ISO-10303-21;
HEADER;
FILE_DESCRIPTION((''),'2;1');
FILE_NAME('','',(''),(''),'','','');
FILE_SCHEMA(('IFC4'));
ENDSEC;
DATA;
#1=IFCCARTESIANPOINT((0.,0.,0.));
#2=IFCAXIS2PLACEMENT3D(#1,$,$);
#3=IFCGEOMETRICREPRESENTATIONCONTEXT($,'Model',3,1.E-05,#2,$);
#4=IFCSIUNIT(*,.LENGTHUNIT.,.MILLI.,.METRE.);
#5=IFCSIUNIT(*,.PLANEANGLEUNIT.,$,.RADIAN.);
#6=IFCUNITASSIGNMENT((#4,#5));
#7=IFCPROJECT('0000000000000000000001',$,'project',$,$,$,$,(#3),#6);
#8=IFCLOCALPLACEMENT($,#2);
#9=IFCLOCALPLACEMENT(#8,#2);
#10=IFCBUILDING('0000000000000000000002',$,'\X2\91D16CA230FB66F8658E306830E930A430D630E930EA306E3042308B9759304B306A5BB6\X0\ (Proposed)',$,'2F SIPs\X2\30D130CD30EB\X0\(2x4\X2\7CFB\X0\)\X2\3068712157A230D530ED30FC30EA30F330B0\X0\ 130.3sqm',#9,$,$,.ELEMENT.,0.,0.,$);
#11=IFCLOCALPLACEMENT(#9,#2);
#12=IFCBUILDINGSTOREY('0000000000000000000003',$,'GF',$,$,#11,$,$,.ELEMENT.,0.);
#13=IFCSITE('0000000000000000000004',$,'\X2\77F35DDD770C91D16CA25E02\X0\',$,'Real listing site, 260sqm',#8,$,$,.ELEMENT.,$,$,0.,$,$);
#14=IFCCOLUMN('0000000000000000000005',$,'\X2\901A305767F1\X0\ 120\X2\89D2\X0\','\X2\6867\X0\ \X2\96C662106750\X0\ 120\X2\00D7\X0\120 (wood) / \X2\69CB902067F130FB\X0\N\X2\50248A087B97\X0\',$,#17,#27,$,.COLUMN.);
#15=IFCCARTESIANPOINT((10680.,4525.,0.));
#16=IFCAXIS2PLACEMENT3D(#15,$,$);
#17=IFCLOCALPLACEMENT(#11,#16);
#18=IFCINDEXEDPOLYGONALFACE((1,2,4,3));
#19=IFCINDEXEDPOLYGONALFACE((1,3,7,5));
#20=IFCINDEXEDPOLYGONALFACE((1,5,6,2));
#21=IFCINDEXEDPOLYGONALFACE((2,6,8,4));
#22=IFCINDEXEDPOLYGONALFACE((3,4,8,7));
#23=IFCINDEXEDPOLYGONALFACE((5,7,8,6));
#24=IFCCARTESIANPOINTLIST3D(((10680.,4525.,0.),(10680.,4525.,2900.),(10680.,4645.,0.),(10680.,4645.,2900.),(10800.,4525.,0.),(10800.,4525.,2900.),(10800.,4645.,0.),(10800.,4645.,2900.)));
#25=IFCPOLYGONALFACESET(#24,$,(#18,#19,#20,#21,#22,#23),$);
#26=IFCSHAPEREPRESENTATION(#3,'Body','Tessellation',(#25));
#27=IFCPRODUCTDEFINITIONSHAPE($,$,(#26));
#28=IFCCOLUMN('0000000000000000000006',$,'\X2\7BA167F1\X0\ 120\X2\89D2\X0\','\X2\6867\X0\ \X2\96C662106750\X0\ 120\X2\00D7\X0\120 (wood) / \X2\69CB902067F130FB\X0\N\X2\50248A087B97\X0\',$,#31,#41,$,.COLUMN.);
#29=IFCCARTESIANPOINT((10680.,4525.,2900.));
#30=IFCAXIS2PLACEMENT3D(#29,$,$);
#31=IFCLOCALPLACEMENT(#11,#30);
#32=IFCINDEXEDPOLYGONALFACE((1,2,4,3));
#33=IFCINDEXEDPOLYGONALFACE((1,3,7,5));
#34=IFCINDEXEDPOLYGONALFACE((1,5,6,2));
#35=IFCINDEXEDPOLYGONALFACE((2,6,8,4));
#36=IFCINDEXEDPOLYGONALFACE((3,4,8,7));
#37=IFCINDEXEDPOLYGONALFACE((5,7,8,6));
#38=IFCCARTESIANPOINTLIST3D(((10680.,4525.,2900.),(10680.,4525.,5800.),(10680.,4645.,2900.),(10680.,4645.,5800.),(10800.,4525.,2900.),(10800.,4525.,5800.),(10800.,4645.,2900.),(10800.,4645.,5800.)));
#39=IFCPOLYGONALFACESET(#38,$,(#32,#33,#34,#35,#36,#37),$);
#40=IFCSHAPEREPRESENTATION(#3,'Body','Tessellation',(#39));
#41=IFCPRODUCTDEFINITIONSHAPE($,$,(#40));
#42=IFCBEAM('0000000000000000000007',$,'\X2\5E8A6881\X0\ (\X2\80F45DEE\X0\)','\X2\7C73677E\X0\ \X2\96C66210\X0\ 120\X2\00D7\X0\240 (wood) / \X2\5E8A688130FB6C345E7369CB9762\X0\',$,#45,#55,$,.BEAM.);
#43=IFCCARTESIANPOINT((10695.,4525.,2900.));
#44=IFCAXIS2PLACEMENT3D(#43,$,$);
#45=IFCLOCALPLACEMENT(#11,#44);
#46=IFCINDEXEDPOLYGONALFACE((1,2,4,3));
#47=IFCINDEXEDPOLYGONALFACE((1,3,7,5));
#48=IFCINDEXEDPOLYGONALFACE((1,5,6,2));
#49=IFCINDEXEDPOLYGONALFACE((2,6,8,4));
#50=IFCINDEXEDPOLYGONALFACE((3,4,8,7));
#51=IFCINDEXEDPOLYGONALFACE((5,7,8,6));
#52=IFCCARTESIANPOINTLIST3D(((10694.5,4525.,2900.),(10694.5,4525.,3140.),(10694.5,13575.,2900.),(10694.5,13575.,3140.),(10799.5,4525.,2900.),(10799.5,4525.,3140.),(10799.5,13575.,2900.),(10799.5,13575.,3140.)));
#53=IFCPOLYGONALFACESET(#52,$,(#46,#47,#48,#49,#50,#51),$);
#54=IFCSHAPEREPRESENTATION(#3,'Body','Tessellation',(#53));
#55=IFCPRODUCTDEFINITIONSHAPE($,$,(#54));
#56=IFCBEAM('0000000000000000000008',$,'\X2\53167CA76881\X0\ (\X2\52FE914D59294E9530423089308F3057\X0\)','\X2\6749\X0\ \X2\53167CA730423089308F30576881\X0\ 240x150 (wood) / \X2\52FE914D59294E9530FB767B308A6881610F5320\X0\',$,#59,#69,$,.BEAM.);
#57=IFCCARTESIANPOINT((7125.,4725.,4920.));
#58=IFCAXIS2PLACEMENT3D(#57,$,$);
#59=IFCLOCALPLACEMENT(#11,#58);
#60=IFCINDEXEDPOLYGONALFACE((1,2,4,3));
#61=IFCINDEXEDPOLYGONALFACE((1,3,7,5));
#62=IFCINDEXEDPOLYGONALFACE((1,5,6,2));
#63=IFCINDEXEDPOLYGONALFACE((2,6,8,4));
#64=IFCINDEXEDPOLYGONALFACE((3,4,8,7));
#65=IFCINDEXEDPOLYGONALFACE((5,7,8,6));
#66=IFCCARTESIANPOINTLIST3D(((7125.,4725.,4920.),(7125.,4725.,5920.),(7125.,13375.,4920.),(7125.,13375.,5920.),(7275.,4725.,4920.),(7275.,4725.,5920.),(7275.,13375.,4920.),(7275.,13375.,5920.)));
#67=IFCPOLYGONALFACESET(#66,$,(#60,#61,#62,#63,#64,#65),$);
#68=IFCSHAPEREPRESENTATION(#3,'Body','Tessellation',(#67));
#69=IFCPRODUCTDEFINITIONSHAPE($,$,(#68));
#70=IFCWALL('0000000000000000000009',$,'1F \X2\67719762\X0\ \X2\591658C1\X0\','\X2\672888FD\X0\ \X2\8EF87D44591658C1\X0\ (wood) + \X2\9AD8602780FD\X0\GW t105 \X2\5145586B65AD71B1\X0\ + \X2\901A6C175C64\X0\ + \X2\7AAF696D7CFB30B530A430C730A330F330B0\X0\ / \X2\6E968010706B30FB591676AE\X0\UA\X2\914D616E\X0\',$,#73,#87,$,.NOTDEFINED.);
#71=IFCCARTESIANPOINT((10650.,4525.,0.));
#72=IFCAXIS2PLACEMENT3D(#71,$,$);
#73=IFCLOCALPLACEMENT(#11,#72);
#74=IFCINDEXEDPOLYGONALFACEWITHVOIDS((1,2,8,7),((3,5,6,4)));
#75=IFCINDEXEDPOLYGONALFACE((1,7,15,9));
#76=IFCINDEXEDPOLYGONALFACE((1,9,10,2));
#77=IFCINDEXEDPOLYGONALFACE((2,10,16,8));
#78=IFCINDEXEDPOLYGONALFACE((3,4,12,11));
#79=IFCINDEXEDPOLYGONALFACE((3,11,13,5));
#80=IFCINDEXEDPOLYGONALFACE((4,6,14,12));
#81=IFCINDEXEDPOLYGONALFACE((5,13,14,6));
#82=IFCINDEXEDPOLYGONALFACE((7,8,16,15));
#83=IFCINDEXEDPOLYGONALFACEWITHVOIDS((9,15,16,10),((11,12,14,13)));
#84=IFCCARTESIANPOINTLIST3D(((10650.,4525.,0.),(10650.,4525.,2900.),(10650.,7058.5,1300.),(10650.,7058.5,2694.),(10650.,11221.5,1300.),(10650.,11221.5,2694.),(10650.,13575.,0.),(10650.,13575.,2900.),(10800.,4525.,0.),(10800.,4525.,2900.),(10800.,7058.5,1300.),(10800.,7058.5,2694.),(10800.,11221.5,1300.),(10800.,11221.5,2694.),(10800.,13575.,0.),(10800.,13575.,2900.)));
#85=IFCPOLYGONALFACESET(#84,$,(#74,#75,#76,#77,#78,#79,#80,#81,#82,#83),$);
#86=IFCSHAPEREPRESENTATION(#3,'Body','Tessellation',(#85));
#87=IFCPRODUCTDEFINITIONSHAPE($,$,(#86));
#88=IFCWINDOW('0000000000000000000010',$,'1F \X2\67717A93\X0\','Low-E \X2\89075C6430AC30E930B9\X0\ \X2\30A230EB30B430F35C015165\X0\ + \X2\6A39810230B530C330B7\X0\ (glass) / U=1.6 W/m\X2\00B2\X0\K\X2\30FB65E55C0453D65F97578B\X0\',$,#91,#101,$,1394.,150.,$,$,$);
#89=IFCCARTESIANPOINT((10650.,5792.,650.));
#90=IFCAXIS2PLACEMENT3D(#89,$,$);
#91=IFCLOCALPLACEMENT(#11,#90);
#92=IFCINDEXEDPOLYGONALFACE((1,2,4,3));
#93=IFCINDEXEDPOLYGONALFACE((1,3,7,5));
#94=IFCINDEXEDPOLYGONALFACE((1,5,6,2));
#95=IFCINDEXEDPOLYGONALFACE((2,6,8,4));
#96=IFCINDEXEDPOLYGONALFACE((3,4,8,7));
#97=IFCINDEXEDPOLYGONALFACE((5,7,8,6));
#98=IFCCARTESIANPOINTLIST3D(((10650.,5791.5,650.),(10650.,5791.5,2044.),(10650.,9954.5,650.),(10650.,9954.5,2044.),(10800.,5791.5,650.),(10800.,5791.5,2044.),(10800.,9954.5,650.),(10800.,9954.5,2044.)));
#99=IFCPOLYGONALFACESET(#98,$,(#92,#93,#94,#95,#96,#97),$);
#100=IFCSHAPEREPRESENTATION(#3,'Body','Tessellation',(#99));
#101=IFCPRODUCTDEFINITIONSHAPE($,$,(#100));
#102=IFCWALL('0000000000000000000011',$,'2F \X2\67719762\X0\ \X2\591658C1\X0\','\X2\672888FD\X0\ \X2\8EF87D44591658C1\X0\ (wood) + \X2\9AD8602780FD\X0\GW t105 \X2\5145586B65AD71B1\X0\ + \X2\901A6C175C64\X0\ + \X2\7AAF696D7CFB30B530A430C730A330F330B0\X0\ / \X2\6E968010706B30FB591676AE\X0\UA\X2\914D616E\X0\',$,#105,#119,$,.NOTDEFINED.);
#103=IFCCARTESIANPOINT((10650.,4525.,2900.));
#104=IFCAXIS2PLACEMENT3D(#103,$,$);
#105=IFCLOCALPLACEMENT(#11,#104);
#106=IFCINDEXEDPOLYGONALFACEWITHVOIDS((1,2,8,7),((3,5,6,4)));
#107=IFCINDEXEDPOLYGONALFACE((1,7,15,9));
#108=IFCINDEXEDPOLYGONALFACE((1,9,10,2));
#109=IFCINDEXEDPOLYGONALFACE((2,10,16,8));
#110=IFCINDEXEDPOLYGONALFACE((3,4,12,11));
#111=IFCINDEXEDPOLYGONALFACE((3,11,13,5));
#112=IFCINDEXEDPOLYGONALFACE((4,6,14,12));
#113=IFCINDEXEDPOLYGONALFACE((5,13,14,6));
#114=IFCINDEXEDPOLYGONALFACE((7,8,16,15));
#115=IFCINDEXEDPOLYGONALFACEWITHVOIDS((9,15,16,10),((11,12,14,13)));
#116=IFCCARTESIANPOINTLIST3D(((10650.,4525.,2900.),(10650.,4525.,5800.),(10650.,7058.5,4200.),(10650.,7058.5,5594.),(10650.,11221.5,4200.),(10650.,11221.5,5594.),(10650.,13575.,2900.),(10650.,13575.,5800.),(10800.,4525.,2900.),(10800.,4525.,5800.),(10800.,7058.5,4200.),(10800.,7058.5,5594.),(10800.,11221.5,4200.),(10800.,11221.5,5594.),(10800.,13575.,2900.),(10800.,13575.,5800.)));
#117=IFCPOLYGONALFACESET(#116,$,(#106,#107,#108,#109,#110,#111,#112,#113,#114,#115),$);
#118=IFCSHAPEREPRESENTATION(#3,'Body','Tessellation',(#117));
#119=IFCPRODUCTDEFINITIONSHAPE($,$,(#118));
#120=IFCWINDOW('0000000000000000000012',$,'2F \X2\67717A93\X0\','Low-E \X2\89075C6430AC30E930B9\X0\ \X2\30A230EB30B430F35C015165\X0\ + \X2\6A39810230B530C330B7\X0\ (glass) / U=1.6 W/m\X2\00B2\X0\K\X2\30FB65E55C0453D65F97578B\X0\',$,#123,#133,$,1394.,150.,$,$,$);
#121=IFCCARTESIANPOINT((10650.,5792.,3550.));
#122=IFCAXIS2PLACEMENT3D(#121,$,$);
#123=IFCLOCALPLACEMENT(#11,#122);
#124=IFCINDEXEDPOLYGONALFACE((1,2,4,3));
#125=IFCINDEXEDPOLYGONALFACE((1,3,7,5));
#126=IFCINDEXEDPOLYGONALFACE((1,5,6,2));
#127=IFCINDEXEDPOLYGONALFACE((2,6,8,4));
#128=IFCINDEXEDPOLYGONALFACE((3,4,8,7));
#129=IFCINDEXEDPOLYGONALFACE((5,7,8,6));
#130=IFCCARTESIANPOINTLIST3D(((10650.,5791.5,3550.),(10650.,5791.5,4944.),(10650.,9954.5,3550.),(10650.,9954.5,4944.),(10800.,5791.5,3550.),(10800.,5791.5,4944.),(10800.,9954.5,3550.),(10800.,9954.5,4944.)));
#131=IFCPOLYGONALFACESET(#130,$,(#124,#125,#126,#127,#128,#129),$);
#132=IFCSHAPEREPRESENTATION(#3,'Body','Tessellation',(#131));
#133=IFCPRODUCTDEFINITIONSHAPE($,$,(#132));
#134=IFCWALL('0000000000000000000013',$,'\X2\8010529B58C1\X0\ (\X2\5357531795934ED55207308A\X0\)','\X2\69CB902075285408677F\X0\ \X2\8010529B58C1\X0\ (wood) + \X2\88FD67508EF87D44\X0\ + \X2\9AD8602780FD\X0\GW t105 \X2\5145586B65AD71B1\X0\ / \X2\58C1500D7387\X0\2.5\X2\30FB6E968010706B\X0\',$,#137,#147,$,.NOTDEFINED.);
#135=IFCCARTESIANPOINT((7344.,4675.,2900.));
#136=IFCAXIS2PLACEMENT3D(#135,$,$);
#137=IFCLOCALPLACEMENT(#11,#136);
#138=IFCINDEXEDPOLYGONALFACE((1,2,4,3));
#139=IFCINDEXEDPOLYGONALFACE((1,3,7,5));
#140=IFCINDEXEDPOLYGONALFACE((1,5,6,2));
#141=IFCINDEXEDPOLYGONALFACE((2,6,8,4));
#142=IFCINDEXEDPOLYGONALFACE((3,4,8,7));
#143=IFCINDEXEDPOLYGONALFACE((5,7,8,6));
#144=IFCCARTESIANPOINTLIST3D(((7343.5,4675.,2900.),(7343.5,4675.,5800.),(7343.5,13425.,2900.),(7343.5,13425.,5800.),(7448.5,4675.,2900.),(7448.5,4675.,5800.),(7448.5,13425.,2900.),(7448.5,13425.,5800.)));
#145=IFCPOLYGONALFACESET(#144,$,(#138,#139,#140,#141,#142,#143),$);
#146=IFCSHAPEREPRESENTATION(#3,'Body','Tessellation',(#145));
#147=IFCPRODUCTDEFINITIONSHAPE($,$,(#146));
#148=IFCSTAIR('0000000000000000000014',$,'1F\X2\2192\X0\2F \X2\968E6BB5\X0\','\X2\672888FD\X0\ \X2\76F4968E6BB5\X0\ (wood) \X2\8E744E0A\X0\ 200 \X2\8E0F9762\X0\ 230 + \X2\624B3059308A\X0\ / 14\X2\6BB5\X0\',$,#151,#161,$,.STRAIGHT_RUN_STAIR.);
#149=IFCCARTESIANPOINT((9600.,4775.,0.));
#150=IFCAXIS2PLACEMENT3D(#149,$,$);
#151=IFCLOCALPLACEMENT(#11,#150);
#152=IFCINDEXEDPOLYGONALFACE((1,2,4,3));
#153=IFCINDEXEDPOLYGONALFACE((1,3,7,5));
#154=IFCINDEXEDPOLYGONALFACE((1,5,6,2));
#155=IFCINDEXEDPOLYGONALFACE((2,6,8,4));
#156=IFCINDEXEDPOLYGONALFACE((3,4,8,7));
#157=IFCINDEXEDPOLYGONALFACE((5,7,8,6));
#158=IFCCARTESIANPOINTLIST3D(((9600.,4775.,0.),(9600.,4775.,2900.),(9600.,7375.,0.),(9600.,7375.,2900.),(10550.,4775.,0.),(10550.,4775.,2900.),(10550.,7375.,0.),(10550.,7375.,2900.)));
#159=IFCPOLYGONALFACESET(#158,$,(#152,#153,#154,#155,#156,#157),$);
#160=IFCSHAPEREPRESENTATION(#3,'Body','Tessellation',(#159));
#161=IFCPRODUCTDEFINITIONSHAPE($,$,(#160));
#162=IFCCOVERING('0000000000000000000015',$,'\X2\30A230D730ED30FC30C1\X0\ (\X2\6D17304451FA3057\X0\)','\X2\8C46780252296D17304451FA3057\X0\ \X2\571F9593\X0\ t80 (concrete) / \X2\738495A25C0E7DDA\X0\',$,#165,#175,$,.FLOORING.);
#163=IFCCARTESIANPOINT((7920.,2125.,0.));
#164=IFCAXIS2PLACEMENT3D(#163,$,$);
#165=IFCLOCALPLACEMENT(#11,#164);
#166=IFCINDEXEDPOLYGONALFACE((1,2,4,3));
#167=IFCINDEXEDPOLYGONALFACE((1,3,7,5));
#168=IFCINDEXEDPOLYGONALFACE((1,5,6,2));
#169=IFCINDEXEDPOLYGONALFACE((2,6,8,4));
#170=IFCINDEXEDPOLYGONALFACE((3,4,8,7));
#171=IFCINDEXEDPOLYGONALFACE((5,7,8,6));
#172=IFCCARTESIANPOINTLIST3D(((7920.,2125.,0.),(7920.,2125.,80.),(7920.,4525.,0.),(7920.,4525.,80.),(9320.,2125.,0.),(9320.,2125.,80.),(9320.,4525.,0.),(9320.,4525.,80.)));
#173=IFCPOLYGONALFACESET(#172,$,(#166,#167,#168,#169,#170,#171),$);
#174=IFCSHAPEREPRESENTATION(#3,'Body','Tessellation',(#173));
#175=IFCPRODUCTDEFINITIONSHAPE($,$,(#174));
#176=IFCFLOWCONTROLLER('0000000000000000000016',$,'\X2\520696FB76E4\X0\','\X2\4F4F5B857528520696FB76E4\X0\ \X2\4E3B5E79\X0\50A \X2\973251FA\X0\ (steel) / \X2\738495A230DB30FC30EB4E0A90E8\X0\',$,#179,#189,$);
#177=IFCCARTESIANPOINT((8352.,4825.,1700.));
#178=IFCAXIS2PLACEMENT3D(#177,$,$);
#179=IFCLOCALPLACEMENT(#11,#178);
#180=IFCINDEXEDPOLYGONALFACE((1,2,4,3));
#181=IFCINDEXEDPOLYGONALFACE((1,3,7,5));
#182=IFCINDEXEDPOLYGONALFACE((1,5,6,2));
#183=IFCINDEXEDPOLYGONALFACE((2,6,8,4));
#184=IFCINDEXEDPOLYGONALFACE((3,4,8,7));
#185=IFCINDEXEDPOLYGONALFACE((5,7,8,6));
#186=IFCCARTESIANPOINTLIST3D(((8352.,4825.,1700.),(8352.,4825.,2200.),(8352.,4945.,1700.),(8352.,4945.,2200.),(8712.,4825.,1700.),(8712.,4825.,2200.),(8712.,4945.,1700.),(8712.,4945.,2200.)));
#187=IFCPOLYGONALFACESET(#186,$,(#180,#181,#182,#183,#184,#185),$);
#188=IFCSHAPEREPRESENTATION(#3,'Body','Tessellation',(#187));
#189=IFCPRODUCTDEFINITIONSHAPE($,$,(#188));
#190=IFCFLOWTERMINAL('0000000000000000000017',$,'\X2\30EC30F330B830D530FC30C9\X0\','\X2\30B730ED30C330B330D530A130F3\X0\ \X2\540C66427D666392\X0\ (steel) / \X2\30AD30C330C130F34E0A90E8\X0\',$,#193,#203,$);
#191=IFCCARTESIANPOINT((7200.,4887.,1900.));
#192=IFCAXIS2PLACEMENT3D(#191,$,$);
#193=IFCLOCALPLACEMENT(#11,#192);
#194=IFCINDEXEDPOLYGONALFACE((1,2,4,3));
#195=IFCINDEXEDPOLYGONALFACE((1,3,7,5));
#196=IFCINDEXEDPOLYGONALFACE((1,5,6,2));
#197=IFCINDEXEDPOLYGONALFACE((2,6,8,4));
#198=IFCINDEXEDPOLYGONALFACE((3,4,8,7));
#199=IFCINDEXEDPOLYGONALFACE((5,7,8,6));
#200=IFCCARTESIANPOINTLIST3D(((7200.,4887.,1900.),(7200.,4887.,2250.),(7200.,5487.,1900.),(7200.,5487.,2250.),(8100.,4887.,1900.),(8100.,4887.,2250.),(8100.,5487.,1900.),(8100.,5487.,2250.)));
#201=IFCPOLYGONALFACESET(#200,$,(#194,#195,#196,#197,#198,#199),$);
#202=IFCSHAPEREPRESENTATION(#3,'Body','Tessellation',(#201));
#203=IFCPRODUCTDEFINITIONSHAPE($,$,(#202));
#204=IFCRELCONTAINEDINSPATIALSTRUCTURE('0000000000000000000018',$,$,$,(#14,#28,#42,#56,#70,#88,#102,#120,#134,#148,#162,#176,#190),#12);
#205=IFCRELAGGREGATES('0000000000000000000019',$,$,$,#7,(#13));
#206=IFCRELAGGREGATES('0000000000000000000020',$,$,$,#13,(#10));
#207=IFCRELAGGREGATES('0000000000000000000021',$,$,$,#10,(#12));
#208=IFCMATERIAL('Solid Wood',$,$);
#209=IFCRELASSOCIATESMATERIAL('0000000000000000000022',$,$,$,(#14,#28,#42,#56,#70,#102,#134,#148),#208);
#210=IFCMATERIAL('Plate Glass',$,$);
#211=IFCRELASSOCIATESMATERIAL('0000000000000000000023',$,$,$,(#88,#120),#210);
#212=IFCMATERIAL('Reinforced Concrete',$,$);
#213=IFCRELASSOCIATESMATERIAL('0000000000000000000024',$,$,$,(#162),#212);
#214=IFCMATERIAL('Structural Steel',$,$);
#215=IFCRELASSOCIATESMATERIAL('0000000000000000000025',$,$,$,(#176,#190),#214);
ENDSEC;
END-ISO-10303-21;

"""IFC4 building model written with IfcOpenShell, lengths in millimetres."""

from ifc_helpers import new_model, si_unit, frame, frame_2d, origin, place, context, project, spatial, rectangle, extrude, material, element, fill, save


model = new_model("IFC4")

# Units and contexts
model_context = context("Model", 3, precision=1e-05, world=origin())
ifc_project = project(units=[si_unit("LENGTHUNIT", "METRE", prefix="MILLI"), si_unit("PLANEANGLEUNIT", "RADIAN")], contexts=[model_context])

# Site, building, storey
site_placement = place(None, origin())
site = spatial("IfcSite", under=ifc_project, at=site_placement, Name="石川県金沢市", ObjectType="Real listing site, 260sqm", CompositionType="ELEMENT", RefElevation=0.0)
building_placement = place(site_placement, origin())
building = spatial("IfcBuilding", under=site, at=building_placement, Name="金沢・書斎とライブラリのある静かな家 (Proposed)", ObjectType="2F SIPsパネル(2x4系)と無垢フローリング 130.3sqm", CompositionType="ELEMENT", ElevationOfRefHeight=0.0, ElevationOfTerrain=0.0)
storey_placement = place(building_placement, origin())
storey = spatial("IfcBuildingStorey", under=building, at=storey_placement, Name="GF", CompositionType="ELEMENT", Elevation=0.0)

# Columns
ifc_material_1 = material(Name="Solid Wood")
column_1_placement = place(storey_placement, frame((10680.0, 4525.0, 0.0)))
element("IfcColumn", 1, at=column_1_placement, inside=storey, material=ifc_material_1, Name="通し柱 120角", Description="桧 集成材 120×120 (wood) / 構造柱・N値計算", PredefinedType="COLUMN", context=model_context, shape_type="SweptSolid", body=[
    extrude(rectangle(XDim=120.0, YDim=120.0, at=frame_2d((60.0, 60.0))), frame((10680.0, 4525.0, 0.0)), (0.0, 0.0, 1.0), 2900.0),
])
column_2_placement = place(storey_placement, frame((10680.0, 4525.0, 2900.0)))
element("IfcColumn", 2, at=column_2_placement, inside=storey, material=ifc_material_1, Name="管柱 120角", Description="桧 集成材 120×120 (wood) / 構造柱・N値計算", PredefinedType="COLUMN", context=model_context, shape_type="SweptSolid", body=[
    extrude(rectangle(XDim=120.0, YDim=120.0, at=frame_2d((60.0, 60.0))), frame((10680.0, 4525.0, 2900.0)), (0.0, 0.0, 1.0), 2900.0),
])

# Beams
beam_1_placement = place(storey_placement, frame((10695.0, 4525.0, 2900.0)))
element("IfcBeam", 3, at=beam_1_placement, inside=storey, material=ifc_material_1, Name="床梁 (胴差)", Description="米松 集成 120×240 (wood) / 床梁・水平構面", PredefinedType="BEAM", context=model_context, shape_type="SweptSolid", body=[
    extrude(rectangle(XDim=105.0, YDim=9050.0, at=frame_2d((52.0, 4525.0))), frame((10695.0, 4525.0, 2900.0)), (0.0, 0.0, 1.0), 240.0),
])
beam_2_placement = place(storey_placement, frame((7125.0, 4725.0, 4920.0)))
element("IfcBeam", 4, at=beam_2_placement, inside=storey, material=ifc_material_1, Name="化粧梁 (勾配天井あらわし)", Description="杉 化粧あらわし梁 240x150 (wood) / 勾配天井・登り梁意匠", PredefinedType="BEAM", context=model_context, shape_type="SweptSolid", body=[
    extrude(rectangle(XDim=150.0, YDim=8650.0, at=frame_2d((75.0, 4325.0))), frame((7125.0, 4725.0, 4920.0)), (0.0, 0.0, 1.0), 1000.0),
])

# Wall, opening, window
wall_1_placement = place(storey_placement, frame((10650.0, 4525.0, 0.0)))
wall_1 = element("IfcWall", 5, at=wall_1_placement, inside=storey, material=ifc_material_1, Name="1F 東面 外壁", Description="木製 軸組外壁 (wood) + 高性能GW t105 充填断熱 + 通気層 + 窯業系サイディング / 準耐火・外皮UA配慮", PredefinedType="NOTDEFINED", context=model_context, shape_type="SweptSolid", body=[
    extrude(rectangle(XDim=150.0, YDim=9050.0, at=frame_2d((75.0, 4525.0))), frame((10650.0, 4525.0, 0.0)), (0.0, 0.0, 1.0), 2900.0),
])
opening_1_placement = place(storey_placement, frame((10650.0, 5792.0, 650.0)))
opening_1 = element("IfcOpeningElement", 6, at=opening_1_placement, cuts=wall_1, PredefinedType="NOTDEFINED", context=model_context, shape_type="SweptSolid", body=[
    extrude(rectangle(XDim=150.0, YDim=4163.0, at=frame_2d((75.0, 2081.0))), frame((10650.0, 5792.0, 650.0)), (0.0, 0.0, 1.0), 1394.0),
])
ifc_material_2 = material(Name="Plate Glass")
window_1_placement = place(storey_placement, frame((10650.0, 5792.0, 650.0)))
window_1 = element("IfcWindow", 7, at=window_1_placement, inside=storey, material=ifc_material_2, Name="1F 東窓", Description="Low-E 複層ガラス アルゴン封入 + 樹脂サッシ (glass) / U=1.6 W/m²K・日射取得型", OverallHeight=1394.0, OverallWidth=150.0, context=model_context, shape_type="SweptSolid", body=[
    extrude(rectangle(XDim=150.0, YDim=4163.0, at=frame_2d((75.0, 2081.0))), frame((10650.0, 5792.0, 650.0)), (0.0, 0.0, 1.0), 1394.0),
])
fill(opening_1, window_1)

# Wall, opening, window
wall_2_placement = place(storey_placement, frame((10650.0, 4525.0, 2900.0)))
wall_2 = element("IfcWall", 8, at=wall_2_placement, inside=storey, material=ifc_material_1, Name="2F 東面 外壁", Description="木製 軸組外壁 (wood) + 高性能GW t105 充填断熱 + 通気層 + 窯業系サイディング / 準耐火・外皮UA配慮", PredefinedType="NOTDEFINED", context=model_context, shape_type="SweptSolid", body=[
    extrude(rectangle(XDim=150.0, YDim=9050.0, at=frame_2d((75.0, 4525.0))), frame((10650.0, 4525.0, 2900.0)), (0.0, 0.0, 1.0), 2900.0),
])
opening_2_placement = place(storey_placement, frame((10650.0, 5792.0, 3550.0)))
opening_2 = element("IfcOpeningElement", 9, at=opening_2_placement, cuts=wall_2, PredefinedType="NOTDEFINED", context=model_context, shape_type="SweptSolid", body=[
    extrude(rectangle(XDim=150.0, YDim=4163.0, at=frame_2d((75.0, 2081.0))), frame((10650.0, 5792.0, 3550.0)), (0.0, 0.0, 1.0), 1394.0),
])
window_2_placement = place(storey_placement, frame((10650.0, 5792.0, 3550.0)))
window_2 = element("IfcWindow", 10, at=window_2_placement, inside=storey, material=ifc_material_2, Name="2F 東窓", Description="Low-E 複層ガラス アルゴン封入 + 樹脂サッシ (glass) / U=1.6 W/m²K・日射取得型", OverallHeight=1394.0, OverallWidth=150.0, context=model_context, shape_type="SweptSolid", body=[
    extrude(rectangle(XDim=150.0, YDim=4163.0, at=frame_2d((75.0, 2081.0))), frame((10650.0, 5792.0, 3550.0)), (0.0, 0.0, 1.0), 1394.0),
])
fill(opening_2, window_2)

# Wall
wall_3_placement = place(storey_placement, frame((7344.0, 4675.0, 2900.0)))
element("IfcWall", 11, at=wall_3_placement, inside=storey, material=ifc_material_1, Name="耐力壁 (南北間仕切り)", Description="構造用合板 耐力壁 (wood) + 製材軸組 + 高性能GW t105 充填断熱 / 壁倍率2.5・準耐火", PredefinedType="NOTDEFINED", context=model_context, shape_type="SweptSolid", body=[
    extrude(rectangle(XDim=105.0, YDim=8750.0, at=frame_2d((52.0, 4375.0))), frame((7344.0, 4675.0, 2900.0)), (0.0, 0.0, 1.0), 2900.0),
])

# Stair
stair_placement = place(storey_placement, frame((9600.0, 4775.0, 0.0)))
element("IfcStair", 12, at=stair_placement, inside=storey, material=ifc_material_1, Name="1F→2F 階段", Description="木製 直階段 (wood) 蹴上 200 踏面 230 + 手すり / 14段", PredefinedType="STRAIGHT_RUN_STAIR", context=model_context, shape_type="SweptSolid", body=[
    extrude(rectangle(XDim=950.0, YDim=2600.0, at=frame_2d((475.0, 1300.0))), frame((9600.0, 4775.0, 0.0)), (0.0, 0.0, 1.0), 2900.0),
])

# Covering
ifc_material_3 = material(Name="Reinforced Concrete")
covering_placement = place(storey_placement, frame((7920.0, 2125.0, 0.0)))
element("IfcCovering", 13, at=covering_placement, inside=storey, material=ifc_material_3, Name="アプローチ (洗い出し)", Description="豆砂利洗い出し 土間 t80 (concrete) / 玄関導線", PredefinedType="FLOORING", context=model_context, shape_type="SweptSolid", body=[
    extrude(rectangle(XDim=1400.0, YDim=2400.0, at=frame_2d((700.0, 1200.0))), frame((7920.0, 2125.0, 0.0)), (0.0, 0.0, 1.0), 80.0),
])

# Flow controller
ifc_material_4 = material(Name="Structural Steel")
flow_controller_placement = place(storey_placement, frame((8352.0, 4825.0, 1700.0)))
element("IfcFlowController", 14, at=flow_controller_placement, inside=storey, material=ifc_material_4, Name="分電盤", Description="住宅用分電盤 主幹50A 露出 (steel) / 玄関ホール上部", context=model_context, shape_type="SweptSolid", body=[
    extrude(rectangle(XDim=360.0, YDim=120.0, at=frame_2d((180.0, 60.0))), frame((8352.0, 4825.0, 1700.0)), (0.0, 0.0, 1.0), 500.0),
])

# Flow terminal
flow_terminal_1_placement = place(storey_placement, frame((7200.0, 4887.0, 1900.0)))
element("IfcFlowTerminal", 15, at=flow_terminal_1_placement, inside=storey, material=ifc_material_4, Name="レンジフード", Description="シロッコファン 同時給排 (steel) / キッチン上部", context=model_context, shape_type="SweptSolid", body=[
    extrude(rectangle(XDim=900.0, YDim=600.0, at=frame_2d((450.0, 300.0))), frame((7200.0, 4887.0, 1900.0)), (0.0, 0.0, 1.0), 350.0),
])

save(model, "model.ifc")
